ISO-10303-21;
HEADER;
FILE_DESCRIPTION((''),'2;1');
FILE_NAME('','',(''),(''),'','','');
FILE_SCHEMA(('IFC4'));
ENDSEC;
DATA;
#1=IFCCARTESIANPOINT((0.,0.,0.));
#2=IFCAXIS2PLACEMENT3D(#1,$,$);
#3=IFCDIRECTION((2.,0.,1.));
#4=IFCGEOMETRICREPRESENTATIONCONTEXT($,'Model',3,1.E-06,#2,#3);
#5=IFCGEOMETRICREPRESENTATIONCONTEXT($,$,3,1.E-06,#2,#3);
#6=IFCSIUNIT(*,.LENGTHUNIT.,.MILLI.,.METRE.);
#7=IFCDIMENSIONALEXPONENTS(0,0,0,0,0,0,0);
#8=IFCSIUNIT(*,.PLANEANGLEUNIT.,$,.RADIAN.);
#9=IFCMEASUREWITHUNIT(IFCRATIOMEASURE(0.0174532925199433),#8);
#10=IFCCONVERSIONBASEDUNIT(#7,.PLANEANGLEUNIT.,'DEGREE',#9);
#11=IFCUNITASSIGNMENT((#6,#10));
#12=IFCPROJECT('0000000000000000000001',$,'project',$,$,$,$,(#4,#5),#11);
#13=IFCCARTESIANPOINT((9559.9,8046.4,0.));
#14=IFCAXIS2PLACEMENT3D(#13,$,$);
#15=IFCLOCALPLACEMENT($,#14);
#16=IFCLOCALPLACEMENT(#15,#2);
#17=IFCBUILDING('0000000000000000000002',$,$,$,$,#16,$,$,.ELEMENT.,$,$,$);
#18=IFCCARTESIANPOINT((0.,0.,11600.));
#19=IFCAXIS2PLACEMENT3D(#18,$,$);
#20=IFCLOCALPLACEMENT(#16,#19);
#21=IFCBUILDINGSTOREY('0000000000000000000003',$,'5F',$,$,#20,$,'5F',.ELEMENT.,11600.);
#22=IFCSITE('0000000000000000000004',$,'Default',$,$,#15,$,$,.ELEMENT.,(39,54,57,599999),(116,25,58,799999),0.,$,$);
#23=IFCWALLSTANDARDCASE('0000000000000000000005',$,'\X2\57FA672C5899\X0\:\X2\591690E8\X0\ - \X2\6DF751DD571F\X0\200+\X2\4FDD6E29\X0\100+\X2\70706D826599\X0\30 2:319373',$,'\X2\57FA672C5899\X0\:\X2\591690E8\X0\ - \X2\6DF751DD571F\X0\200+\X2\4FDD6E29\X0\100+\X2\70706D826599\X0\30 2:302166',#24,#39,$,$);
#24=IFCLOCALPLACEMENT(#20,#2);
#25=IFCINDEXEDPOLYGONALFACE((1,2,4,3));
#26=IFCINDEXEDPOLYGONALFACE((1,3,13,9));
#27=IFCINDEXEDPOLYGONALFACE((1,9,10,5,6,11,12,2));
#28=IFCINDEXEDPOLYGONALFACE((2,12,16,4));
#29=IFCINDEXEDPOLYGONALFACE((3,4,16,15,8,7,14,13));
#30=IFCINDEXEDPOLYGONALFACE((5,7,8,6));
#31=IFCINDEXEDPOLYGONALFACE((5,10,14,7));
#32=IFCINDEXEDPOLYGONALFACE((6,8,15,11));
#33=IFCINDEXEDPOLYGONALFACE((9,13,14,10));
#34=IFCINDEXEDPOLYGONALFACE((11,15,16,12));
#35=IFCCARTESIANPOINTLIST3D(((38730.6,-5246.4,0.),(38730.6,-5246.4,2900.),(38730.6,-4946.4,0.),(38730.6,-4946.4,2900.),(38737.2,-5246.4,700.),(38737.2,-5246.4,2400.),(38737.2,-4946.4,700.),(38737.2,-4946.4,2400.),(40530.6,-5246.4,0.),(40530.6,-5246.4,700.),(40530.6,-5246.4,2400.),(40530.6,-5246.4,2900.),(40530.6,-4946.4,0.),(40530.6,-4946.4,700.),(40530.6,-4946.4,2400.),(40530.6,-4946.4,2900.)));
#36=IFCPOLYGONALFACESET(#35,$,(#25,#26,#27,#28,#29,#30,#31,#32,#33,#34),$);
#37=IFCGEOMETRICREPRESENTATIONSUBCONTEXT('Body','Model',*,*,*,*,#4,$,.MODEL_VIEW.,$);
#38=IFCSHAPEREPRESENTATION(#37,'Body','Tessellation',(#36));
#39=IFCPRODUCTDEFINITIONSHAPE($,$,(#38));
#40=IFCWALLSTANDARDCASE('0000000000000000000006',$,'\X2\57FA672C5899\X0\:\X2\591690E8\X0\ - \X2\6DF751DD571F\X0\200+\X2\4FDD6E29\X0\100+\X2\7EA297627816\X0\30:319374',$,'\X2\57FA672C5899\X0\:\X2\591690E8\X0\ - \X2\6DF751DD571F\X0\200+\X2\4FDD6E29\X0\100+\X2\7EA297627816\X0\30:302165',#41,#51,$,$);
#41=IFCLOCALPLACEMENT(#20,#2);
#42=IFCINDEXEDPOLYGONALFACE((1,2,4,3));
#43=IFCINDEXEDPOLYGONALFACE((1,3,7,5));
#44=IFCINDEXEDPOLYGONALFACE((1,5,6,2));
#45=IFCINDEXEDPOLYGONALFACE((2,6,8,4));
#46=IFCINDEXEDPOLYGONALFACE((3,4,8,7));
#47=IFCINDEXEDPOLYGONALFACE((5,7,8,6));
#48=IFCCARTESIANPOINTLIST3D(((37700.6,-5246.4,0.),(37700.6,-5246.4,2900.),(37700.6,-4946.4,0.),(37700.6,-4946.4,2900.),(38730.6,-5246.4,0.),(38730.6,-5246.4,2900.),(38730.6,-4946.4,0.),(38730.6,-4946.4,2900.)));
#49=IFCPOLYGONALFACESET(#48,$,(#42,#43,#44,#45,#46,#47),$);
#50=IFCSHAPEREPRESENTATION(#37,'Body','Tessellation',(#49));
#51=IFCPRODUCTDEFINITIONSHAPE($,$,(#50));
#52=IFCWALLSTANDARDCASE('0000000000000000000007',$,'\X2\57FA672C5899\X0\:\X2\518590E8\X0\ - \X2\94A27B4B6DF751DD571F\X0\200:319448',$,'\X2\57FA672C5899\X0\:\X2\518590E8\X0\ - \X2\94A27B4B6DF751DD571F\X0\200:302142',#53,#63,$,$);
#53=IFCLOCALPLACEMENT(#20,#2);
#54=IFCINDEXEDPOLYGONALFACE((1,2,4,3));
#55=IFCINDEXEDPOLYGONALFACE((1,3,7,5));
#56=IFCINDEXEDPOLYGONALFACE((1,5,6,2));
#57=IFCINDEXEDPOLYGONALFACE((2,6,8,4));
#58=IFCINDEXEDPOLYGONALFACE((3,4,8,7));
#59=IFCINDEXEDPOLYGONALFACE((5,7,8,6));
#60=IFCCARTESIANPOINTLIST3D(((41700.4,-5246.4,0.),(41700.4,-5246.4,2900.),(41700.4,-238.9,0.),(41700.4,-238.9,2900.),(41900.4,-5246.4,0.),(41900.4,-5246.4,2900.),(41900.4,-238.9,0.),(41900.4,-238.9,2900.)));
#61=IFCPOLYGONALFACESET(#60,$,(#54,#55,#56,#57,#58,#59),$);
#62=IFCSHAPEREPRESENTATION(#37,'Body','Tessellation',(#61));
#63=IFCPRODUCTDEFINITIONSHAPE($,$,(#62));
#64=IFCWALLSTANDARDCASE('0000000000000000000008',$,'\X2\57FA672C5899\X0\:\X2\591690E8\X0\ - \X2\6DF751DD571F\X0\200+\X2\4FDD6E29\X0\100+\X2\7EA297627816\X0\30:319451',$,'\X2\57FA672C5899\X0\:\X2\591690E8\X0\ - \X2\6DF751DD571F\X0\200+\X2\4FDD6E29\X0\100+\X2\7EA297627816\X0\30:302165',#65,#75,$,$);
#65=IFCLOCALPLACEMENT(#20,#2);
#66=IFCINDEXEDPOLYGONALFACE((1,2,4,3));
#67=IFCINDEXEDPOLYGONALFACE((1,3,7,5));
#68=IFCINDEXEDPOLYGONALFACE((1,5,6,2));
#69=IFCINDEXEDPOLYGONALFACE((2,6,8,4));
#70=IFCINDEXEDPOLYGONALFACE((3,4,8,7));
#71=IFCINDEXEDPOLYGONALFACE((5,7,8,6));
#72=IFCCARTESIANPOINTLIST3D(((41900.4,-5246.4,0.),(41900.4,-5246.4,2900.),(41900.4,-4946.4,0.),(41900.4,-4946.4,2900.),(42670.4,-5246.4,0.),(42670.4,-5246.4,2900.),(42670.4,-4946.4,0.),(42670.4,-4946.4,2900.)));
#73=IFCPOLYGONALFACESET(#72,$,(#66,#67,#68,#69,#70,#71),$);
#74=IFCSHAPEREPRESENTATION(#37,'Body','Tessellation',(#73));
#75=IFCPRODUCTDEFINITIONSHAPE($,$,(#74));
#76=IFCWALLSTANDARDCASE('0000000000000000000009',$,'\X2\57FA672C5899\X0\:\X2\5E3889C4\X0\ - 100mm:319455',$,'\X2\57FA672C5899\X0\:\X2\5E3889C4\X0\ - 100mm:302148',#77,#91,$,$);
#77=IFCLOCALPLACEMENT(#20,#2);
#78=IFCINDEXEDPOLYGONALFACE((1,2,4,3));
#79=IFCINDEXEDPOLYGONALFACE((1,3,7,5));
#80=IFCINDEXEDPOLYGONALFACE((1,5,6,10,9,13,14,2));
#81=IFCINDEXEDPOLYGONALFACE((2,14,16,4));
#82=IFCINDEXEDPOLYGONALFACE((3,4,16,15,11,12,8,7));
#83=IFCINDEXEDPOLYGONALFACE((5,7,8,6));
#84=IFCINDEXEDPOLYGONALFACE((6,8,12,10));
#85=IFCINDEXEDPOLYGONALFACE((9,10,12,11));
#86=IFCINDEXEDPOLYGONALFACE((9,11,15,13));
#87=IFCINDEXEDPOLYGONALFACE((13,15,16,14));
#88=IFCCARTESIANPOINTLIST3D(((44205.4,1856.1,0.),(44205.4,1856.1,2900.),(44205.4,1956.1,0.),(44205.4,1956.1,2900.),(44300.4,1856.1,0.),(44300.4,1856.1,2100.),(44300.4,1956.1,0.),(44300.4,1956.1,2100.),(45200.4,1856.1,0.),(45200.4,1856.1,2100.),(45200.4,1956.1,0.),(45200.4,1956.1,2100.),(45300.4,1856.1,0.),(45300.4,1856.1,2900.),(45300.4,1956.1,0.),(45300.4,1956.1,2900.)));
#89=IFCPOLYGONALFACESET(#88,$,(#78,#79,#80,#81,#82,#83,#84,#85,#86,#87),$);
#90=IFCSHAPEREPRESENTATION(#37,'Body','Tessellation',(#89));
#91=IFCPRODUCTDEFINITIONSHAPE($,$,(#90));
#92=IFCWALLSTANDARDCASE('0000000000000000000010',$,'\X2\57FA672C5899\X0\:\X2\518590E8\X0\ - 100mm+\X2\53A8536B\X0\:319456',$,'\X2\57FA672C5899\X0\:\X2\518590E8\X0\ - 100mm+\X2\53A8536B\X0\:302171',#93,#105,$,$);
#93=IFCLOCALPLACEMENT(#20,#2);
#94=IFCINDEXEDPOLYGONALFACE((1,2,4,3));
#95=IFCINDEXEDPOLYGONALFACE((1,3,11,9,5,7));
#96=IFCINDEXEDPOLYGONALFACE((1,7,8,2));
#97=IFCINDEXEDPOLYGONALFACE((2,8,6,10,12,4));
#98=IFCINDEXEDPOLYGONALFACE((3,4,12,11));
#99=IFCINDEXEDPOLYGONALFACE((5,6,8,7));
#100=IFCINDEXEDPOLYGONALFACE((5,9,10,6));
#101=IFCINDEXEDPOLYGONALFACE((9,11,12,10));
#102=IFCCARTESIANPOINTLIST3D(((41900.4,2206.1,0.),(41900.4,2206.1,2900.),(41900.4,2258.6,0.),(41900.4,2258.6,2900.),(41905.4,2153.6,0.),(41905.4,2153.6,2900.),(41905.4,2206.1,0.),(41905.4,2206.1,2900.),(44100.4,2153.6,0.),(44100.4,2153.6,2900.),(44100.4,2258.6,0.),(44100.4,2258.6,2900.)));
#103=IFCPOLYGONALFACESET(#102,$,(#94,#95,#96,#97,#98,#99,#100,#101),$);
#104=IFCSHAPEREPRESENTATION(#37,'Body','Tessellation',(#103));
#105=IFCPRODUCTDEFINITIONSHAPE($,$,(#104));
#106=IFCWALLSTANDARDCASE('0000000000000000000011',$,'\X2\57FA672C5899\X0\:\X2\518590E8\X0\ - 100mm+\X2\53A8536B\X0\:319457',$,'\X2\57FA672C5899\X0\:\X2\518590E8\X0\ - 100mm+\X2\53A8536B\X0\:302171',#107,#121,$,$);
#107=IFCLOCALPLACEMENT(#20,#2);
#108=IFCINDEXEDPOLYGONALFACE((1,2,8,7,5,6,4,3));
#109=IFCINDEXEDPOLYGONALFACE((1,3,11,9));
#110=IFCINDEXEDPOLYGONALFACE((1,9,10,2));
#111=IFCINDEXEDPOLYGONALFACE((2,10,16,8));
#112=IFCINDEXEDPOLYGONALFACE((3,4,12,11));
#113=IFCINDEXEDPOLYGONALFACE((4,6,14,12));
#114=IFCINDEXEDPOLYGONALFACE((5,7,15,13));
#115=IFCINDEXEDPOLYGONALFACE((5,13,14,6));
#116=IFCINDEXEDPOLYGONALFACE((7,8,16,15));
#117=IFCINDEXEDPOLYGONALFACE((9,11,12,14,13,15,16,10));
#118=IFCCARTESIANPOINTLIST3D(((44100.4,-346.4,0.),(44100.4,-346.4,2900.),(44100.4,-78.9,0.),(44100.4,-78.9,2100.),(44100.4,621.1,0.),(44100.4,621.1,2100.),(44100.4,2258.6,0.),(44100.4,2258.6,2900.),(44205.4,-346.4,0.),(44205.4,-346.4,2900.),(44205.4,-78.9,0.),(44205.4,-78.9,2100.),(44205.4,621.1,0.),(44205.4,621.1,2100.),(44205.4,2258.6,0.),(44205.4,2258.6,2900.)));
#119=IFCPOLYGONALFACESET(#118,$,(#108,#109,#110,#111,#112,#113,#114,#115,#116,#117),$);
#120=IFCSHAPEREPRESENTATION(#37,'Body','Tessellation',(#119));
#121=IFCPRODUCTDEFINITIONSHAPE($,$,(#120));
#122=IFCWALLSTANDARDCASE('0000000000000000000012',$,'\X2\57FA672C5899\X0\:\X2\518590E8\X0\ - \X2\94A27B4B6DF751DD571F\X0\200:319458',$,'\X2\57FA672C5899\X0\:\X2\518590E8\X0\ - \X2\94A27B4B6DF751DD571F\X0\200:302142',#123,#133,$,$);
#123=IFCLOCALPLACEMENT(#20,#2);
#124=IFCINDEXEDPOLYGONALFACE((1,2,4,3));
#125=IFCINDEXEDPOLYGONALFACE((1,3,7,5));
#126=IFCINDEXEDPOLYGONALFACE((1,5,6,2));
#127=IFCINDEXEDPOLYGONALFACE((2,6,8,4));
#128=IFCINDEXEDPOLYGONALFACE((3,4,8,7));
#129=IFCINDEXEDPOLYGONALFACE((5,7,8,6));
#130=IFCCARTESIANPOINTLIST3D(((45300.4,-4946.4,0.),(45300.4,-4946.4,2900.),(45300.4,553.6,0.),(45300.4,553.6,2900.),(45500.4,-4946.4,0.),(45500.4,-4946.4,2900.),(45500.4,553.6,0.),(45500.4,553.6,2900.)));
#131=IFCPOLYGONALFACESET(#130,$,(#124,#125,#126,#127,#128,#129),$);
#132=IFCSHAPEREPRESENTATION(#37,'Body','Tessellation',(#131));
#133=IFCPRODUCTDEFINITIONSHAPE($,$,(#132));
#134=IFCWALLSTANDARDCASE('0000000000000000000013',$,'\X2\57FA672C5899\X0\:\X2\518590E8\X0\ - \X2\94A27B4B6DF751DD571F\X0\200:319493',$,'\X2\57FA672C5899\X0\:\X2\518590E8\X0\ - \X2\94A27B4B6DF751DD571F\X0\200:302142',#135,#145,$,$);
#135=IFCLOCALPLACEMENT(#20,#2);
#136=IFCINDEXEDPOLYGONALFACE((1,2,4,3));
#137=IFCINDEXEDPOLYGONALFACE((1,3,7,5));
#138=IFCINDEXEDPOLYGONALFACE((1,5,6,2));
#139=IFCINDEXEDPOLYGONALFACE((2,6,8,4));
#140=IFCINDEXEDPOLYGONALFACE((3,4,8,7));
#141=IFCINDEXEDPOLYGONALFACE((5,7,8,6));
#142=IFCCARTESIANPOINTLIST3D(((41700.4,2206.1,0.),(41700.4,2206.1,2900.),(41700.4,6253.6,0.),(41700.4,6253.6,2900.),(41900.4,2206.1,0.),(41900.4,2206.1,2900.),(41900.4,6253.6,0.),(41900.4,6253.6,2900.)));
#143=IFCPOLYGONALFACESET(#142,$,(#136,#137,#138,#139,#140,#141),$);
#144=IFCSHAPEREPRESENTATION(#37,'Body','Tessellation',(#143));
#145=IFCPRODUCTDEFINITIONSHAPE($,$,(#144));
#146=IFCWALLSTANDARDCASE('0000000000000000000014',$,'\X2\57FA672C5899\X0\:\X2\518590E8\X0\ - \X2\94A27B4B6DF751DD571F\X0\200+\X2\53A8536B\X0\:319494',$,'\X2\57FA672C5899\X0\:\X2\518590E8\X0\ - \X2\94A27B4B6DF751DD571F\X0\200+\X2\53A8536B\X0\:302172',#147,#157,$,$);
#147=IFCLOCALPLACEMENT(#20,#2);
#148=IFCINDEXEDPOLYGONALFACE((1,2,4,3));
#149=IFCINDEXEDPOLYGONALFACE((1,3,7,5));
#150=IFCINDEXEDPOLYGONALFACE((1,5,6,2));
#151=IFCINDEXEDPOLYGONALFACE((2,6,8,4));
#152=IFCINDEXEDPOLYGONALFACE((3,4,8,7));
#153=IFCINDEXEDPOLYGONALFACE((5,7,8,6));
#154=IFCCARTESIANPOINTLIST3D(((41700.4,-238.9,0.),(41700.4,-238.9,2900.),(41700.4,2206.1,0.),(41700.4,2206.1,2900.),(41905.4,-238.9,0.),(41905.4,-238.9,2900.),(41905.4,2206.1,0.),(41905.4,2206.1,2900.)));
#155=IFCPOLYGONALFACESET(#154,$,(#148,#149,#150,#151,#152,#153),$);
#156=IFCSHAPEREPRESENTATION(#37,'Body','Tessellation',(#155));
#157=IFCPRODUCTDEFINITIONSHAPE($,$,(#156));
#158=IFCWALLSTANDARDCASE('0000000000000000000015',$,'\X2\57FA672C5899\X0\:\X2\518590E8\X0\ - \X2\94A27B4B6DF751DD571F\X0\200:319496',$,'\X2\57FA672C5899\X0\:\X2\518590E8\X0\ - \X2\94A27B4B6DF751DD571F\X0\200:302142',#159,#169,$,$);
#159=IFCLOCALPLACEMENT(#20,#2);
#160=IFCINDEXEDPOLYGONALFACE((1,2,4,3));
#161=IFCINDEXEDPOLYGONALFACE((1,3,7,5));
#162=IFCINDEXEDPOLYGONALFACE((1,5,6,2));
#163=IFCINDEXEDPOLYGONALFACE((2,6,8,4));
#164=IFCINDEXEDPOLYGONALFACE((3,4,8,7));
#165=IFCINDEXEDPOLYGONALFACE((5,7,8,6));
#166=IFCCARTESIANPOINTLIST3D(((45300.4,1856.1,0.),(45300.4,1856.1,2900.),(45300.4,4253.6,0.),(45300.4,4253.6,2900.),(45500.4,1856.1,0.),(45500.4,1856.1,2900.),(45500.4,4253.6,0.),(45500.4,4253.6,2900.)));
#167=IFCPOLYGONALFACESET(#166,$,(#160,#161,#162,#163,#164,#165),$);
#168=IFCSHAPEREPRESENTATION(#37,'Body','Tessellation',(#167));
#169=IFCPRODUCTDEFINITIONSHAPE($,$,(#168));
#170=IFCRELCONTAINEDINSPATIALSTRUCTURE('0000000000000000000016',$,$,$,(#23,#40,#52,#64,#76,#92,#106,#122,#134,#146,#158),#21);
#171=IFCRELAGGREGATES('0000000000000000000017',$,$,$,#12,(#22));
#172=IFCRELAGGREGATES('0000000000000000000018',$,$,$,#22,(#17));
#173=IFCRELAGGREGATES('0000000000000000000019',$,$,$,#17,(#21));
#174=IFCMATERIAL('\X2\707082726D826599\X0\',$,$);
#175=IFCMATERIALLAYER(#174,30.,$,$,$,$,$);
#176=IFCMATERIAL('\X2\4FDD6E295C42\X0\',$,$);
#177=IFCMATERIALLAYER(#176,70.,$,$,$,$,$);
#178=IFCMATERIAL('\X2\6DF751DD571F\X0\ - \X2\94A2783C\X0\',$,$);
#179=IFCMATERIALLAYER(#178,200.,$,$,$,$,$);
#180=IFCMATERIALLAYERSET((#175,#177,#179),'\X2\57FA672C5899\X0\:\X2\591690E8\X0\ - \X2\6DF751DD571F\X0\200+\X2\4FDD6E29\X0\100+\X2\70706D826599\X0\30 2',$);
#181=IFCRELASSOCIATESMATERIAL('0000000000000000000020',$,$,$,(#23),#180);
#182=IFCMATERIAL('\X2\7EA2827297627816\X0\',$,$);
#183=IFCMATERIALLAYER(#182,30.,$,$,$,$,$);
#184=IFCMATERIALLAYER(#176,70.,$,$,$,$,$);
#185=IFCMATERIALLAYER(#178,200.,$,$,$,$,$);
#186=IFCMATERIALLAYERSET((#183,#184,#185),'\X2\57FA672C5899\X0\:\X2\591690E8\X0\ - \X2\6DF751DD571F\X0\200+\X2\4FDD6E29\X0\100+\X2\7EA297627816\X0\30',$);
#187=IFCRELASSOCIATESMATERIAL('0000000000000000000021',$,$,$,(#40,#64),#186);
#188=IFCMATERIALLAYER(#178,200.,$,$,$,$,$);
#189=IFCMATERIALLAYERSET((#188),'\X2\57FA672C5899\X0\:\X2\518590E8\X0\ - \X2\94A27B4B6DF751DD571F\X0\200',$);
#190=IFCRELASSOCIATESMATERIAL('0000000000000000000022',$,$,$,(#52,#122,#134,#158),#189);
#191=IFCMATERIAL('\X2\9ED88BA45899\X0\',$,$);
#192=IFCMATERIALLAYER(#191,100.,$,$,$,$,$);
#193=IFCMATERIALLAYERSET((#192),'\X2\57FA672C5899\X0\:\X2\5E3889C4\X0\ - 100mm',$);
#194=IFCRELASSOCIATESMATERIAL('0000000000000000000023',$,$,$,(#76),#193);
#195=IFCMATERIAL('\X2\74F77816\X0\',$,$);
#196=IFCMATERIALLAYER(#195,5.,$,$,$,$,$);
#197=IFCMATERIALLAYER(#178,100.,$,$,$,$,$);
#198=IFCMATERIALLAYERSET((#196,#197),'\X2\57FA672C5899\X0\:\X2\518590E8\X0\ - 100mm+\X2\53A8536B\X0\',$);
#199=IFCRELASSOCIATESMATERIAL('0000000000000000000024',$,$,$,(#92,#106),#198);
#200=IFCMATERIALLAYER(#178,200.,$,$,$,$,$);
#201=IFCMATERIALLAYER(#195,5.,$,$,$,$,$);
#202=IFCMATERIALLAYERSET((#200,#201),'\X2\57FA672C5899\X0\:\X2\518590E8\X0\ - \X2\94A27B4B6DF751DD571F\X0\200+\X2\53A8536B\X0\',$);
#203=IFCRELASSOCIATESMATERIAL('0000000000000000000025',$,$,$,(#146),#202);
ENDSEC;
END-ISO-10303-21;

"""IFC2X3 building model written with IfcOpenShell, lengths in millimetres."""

from ifc_helpers import new_model, entity, si_unit, converted_unit, direction, frame, frame_2d, origin, place, context, subcontext, project, spatial, polyline, rectangle, outline, extrude, material, layer, layer_set, layer_usage, element, save


model = new_model("IFC2X3")

# Units and contexts
model_context = context("Model", 3, precision=1e-06, world=origin(), true_north=direction((2.0, 0.0, 1.0)))
context_of_model = context(None, 3, precision=1e-06, world=origin(), true_north=direction((2.0, 0.0, 1.0)))
body_context = subcontext(model_context, "Body", "Model", "MODEL_VIEW")
ifc_project = project(units=[si_unit("LENGTHUNIT", "METRE", prefix="MILLI"), converted_unit("PLANEANGLEUNIT", "DEGREE", entity("IfcRatioMeasure", 0.0174532925199433), si_unit("PLANEANGLEUNIT", "RADIAN"), dimensions=[0, 0, 0, 0, 0, 0, 0])], contexts=[model_context, context_of_model])

# Site, building, storey
site_placement = place(None, frame((9559.9, 8046.4, 0.0)))
site = spatial("IfcSite", under=ifc_project, at=site_placement, Name="Default", CompositionType="ELEMENT", RefLatitude=(39, 54, 57, 599999), RefLongitude=(116, 25, 58, 799999), RefElevation=0.0)
building_placement = place(site_placement, origin())
building = spatial("IfcBuilding", under=site, at=building_placement, CompositionType="ELEMENT")
storey_placement = place(building_placement, frame((0.0, 0.0, 11600.0)))
storey = spatial("IfcBuildingStorey", under=building, at=storey_placement, Name="5F", LongName="5F", CompositionType="ELEMENT", Elevation=11600.0)

# Shared definitions
ifc_material_1 = material(Name="混凝土 - 钢砼")
ifc_layer_1 = layer(ifc_material_1, 200.0)
ifc_layer_set_1 = layer_set([ifc_layer_1], Name="基本墙:内部 - 钢筋混凝土200")
ifc_material_2 = material(Name="红色面砖")
ifc_layer_2 = layer(ifc_material_2, 30.0)
ifc_material_3 = material(Name="保温层")
ifc_layer_3 = layer(ifc_material_3, 70.0)
ifc_layer_4 = layer(ifc_material_1, 200.0)
ifc_layer_set_2 = layer_set([ifc_layer_2, ifc_layer_3, ifc_layer_4], Name="基本墙:外部 - 混凝土200+保温100+红面砖30")

# Shared definitions
ifc_material_4 = material(Name="默认墙")
ifc_layer_5 = layer(ifc_material_4, 100.0)
ifc_layer_set_3 = layer_set([ifc_layer_5], Name="基本墙:常规 - 100mm")

# Shared definitions
ifc_material_5 = material(Name="瓷砖")
ifc_layer_6 = layer(ifc_material_5, 5.0)
ifc_layer_7 = layer(ifc_material_1, 100.0)
ifc_layer_set_4 = layer_set([ifc_layer_6, ifc_layer_7], Name="基本墙:内部 - 100mm+厨卫")

# Shared definitions
ifc_layer_8 = layer(ifc_material_1, 200.0)
ifc_layer_9 = layer(ifc_material_5, 5.0)
ifc_layer_set_5 = layer_set([ifc_layer_8, ifc_layer_9], Name="基本墙:内部 - 钢筋混凝土200+厨卫")

# Wall, opening
ifc_material_6 = material(Name="灰色涂料")
ifc_layer_10 = layer(ifc_material_6, 30.0)
ifc_layer_11 = layer(ifc_material_3, 70.0)
ifc_layer_12 = layer(ifc_material_1, 200.0)
ifc_layer_set_6 = layer_set([ifc_layer_10, ifc_layer_11, ifc_layer_12], Name="基本墙:外部 - 混凝土200+保温100+灰涂料30 2")
ifc_layer_usage_1 = layer_usage(ifc_layer_set_6, "AXIS2", "NEGATIVE", 150.0)
wall_1_placement = place(storey_placement, frame((40530.6, -5096.4, 0.0), z_axis=(0.0, 0.0, 1.0), x_axis=(-1.0, 0.0, 0.0)))
wall_1 = element("IfcWallStandardCase", 1, at=wall_1_placement, inside=storey, material=ifc_layer_usage_1, Name="基本墙:外部 - 混凝土200+保温100+灰涂料30 2:319373", ObjectType="基本墙:外部 - 混凝土200+保温100+灰涂料30 2:302166", context=body_context, shape_type="SweptSolid", body=[
    extrude(rectangle(XDim=1800.0, YDim=300.0, at=frame_2d((900.0, 0.0), x_axis=(-1.0, 0.0))), origin(), (0.0, 0.0, 1.0), 2900.0),
])
opening_1_placement = place(wall_1_placement, frame((-6.6, -150.0, 700.0)))
element("IfcOpeningElement", 2, at=opening_1_placement, cuts=wall_1, ObjectType="Opening", context=body_context, shape_type="SweptSolid", body=[
    extrude(rectangle(XDim=1700.0, YDim=1800.0, at=frame_2d((850.0, 900.0), x_axis=(1.0, 0.0))), frame((0.0, 0.0, 0.0), z_axis=(0.0, 1.0, 0.0), x_axis=(0.0, 0.0, 1.0)), (0.0, 0.0, 1.0), 300.0),
])

# Walls
ifc_layer_usage_2 = layer_usage(ifc_layer_set_2, "AXIS2", "NEGATIVE", 150.0)
wall_2_placement = place(storey_placement, frame((38730.6, -5096.4, 0.0), z_axis=(0.0, 0.0, 1.0), x_axis=(-1.0, 0.0, 0.0)))
element("IfcWallStandardCase", 3, at=wall_2_placement, inside=storey, material=ifc_layer_usage_2, Name="基本墙:外部 - 混凝土200+保温100+红面砖30:319374", ObjectType="基本墙:外部 - 混凝土200+保温100+红面砖30:302165", context=body_context, shape_type="SweptSolid", body=[
    extrude(rectangle(XDim=1030.0, YDim=300.0, at=frame_2d((515.0, 0.0), x_axis=(-1.0, 0.0))), origin(), (0.0, 0.0, 1.0), 2900.0),
])
ifc_layer_usage_3 = layer_usage(ifc_layer_set_1, "AXIS2", "NEGATIVE", 100.0)
wall_3_placement = place(storey_placement, frame((41800.4, -5246.4, 0.0), z_axis=(0.0, 0.0, 1.0), x_axis=(0.0, 1.0, 0.0)))
element("IfcWallStandardCase", 4, at=wall_3_placement, inside=storey, material=ifc_layer_usage_3, Name="基本墙:内部 - 钢筋混凝土200:319448", ObjectType="基本墙:内部 - 钢筋混凝土200:302142", context=body_context, shape_type="SweptSolid", body=[
    extrude(rectangle(XDim=5007.5, YDim=200.0, at=frame_2d((2503.8, 0.0), x_axis=(-1.0, 0.0))), origin(), (0.0, 0.0, 1.0), 2900.0),
])
ifc_layer_usage_4 = layer_usage(ifc_layer_set_2, "AXIS2", "POSITIVE", -150.0)
wall_4_placement = place(storey_placement, frame((41900.4, -5096.4, 0.0)))
element("IfcWallStandardCase", 5, at=wall_4_placement, inside=storey, material=ifc_layer_usage_4, Name="基本墙:外部 - 混凝土200+保温100+红面砖30:319451", ObjectType="基本墙:外部 - 混凝土200+保温100+红面砖30:302165", context=body_context, shape_type="SweptSolid", body=[
    extrude(rectangle(XDim=770.0, YDim=300.0, at=frame_2d((385.0, 0.0), x_axis=(-1.0, 0.0))), origin(), (0.0, 0.0, 1.0), 2900.0),
])

# Wall, opening
ifc_layer_usage_5 = layer_usage(ifc_layer_set_3, "AXIS2", "NEGATIVE", 50.0)
wall_5_placement = place(storey_placement, frame((44205.4, 1906.1, 0.0)))
wall_5 = element("IfcWallStandardCase", 6, at=wall_5_placement, inside=storey, material=ifc_layer_usage_5, Name="基本墙:常规 - 100mm:319455", ObjectType="基本墙:常规 - 100mm:302148", context=body_context, shape_type="SweptSolid", body=[
    extrude(rectangle(XDim=1095.0, YDim=100.0, at=frame_2d((547.5, 0.0), x_axis=(-1.0, 0.0))), origin(), (0.0, 0.0, 1.0), 2900.0),
])
opening_2_placement = place(wall_5_placement, frame((95.0, -50.0, 0.0)))
element("IfcOpeningElement", 7, at=opening_2_placement, cuts=wall_5, ObjectType="Opening", context=body_context, shape_type="SweptSolid", body=[
    extrude(rectangle(XDim=2100.0, YDim=900.0, at=frame_2d((1050.0, 450.0), x_axis=(1.0, 0.0))), frame((0.0, 0.0, 0.0), z_axis=(0.0, 1.0, 0.0), x_axis=(0.0, 0.0, 1.0)), (0.0, 0.0, 1.0), 100.0),
])

# Wall
ifc_layer_usage_6 = layer_usage(ifc_layer_set_4, "AXIS2", "POSITIVE", -52.5)
wall_6_placement = place(storey_placement, frame((41900.4, 2206.1, 0.0)))
element("IfcWallStandardCase", 8, at=wall_6_placement, inside=storey, material=ifc_layer_usage_6, Name="基本墙:内部 - 100mm+厨卫:319456", ObjectType="基本墙:内部 - 100mm+厨卫:302171", context=body_context, shape_type="SweptSolid", body=[
    extrude(outline(polyline([(2200.0, -52.5), (2200.0, 52.5), (0.0, 52.5), (0.0, 0.0), (5.0, 0.0), (5.0, -52.5), (2200.0, -52.5)])), origin(), (0.0, 0.0, 1.0), 2900.0),
])

# Wall, opening
ifc_layer_usage_7 = layer_usage(ifc_layer_set_4, "AXIS2", "POSITIVE", -52.5)
wall_7_placement = place(storey_placement, frame((44152.9, 2258.6, 0.0), z_axis=(0.0, 0.0, 1.0), x_axis=(0.0, -1.0, 0.0)))
wall_7 = element("IfcWallStandardCase", 9, at=wall_7_placement, inside=storey, material=ifc_layer_usage_7, Name="基本墙:内部 - 100mm+厨卫:319457", ObjectType="基本墙:内部 - 100mm+厨卫:302171", context=body_context, shape_type="SweptSolid", body=[
    extrude(rectangle(XDim=2605.0, YDim=105.0, at=frame_2d((1302.5, 0.0), x_axis=(-1.0, 0.0))), origin(), (0.0, 0.0, 1.0), 2900.0),
])
opening_3_placement = place(wall_7_placement, frame((2337.5, 52.5, 0.0)))
element("IfcOpeningElement", 10, at=opening_3_placement, cuts=wall_7, ObjectType="Opening", context=body_context, shape_type="SweptSolid", body=[
    extrude(rectangle(XDim=2100.0, YDim=700.0, at=frame_2d((1050.0, 350.0), x_axis=(1.0, 0.0))), frame((0.0, 0.0, 0.0), z_axis=(0.0, -1.0, 0.0), x_axis=(0.0, 0.0, 1.0)), (0.0, 0.0, 1.0), 105.0),
])

# Walls
ifc_layer_usage_8 = layer_usage(ifc_layer_set_1, "AXIS2", "POSITIVE", -100.0)
wall_8_placement = place(storey_placement, frame((45400.4, 553.6, 0.0), z_axis=(0.0, 0.0, 1.0), x_axis=(0.0, -1.0, 0.0)))
element("IfcWallStandardCase", 11, at=wall_8_placement, inside=storey, material=ifc_layer_usage_8, Name="基本墙:内部 - 钢筋混凝土200:319458", ObjectType="基本墙:内部 - 钢筋混凝土200:302142", context=body_context, shape_type="SweptSolid", body=[
    extrude(rectangle(XDim=5500.0, YDim=200.0, at=frame_2d((2750.0, 0.0), x_axis=(-1.0, 0.0))), origin(), (0.0, 0.0, 1.0), 2900.0),
])
ifc_layer_usage_9 = layer_usage(ifc_layer_set_1, "AXIS2", "NEGATIVE", 100.0)
wall_9_placement = place(storey_placement, frame((41800.4, 2206.1, 0.0), z_axis=(0.0, 0.0, 1.0), x_axis=(0.0, 1.0, 0.0)))
element("IfcWallStandardCase", 12, at=wall_9_placement, inside=storey, material=ifc_layer_usage_9, Name="基本墙:内部 - 钢筋混凝土200:319493", ObjectType="基本墙:内部 - 钢筋混凝土200:302142", context=body_context, shape_type="SweptSolid", body=[
    extrude(rectangle(XDim=4047.5, YDim=200.0, at=frame_2d((2023.8, 0.0), x_axis=(-1.0, 0.0))), origin(), (0.0, 0.0, 1.0), 2900.0),
])
ifc_layer_usage_10 = layer_usage(ifc_layer_set_5, "AXIS2", "NEGATIVE", 102.5)
wall_10_placement = place(storey_placement, frame((41802.9, -238.9, 0.0), z_axis=(0.0, 0.0, 1.0), x_axis=(0.0, 1.0, 0.0)))
element("IfcWallStandardCase", 13, at=wall_10_placement, inside=storey, material=ifc_layer_usage_10, Name="基本墙:内部 - 钢筋混凝土200+厨卫:319494", ObjectType="基本墙:内部 - 钢筋混凝土200+厨卫:302172", context=body_context, shape_type="SweptSolid", body=[
    extrude(rectangle(XDim=2445.0, YDim=205.0, at=frame_2d((1222.5, 0.0), x_axis=(-1.0, 0.0))), origin(), (0.0, 0.0, 1.0), 2900.0),
])
ifc_layer_usage_11 = layer_usage(ifc_layer_set_1, "AXIS2", "NEGATIVE", 100.0)
wall_11_placement = place(storey_placement, frame((45400.4, 4253.6, 0.0), z_axis=(0.0, 0.0, 1.0), x_axis=(0.0, -1.0, 0.0)))
element("IfcWallStandardCase", 14, at=wall_11_placement, inside=storey, material=ifc_layer_usage_11, Name="基本墙:内部 - 钢筋混凝土200:319496", ObjectType="基本墙:内部 - 钢筋混凝土200:302142", context=body_context, shape_type="SweptSolid", body=[
    extrude(rectangle(XDim=2397.5, YDim=200.0, at=frame_2d((1198.8, 0.0), x_axis=(-1.0, 0.0))), origin(), (0.0, 0.0, 1.0), 2900.0),
])

save(model, "model.ifc")
